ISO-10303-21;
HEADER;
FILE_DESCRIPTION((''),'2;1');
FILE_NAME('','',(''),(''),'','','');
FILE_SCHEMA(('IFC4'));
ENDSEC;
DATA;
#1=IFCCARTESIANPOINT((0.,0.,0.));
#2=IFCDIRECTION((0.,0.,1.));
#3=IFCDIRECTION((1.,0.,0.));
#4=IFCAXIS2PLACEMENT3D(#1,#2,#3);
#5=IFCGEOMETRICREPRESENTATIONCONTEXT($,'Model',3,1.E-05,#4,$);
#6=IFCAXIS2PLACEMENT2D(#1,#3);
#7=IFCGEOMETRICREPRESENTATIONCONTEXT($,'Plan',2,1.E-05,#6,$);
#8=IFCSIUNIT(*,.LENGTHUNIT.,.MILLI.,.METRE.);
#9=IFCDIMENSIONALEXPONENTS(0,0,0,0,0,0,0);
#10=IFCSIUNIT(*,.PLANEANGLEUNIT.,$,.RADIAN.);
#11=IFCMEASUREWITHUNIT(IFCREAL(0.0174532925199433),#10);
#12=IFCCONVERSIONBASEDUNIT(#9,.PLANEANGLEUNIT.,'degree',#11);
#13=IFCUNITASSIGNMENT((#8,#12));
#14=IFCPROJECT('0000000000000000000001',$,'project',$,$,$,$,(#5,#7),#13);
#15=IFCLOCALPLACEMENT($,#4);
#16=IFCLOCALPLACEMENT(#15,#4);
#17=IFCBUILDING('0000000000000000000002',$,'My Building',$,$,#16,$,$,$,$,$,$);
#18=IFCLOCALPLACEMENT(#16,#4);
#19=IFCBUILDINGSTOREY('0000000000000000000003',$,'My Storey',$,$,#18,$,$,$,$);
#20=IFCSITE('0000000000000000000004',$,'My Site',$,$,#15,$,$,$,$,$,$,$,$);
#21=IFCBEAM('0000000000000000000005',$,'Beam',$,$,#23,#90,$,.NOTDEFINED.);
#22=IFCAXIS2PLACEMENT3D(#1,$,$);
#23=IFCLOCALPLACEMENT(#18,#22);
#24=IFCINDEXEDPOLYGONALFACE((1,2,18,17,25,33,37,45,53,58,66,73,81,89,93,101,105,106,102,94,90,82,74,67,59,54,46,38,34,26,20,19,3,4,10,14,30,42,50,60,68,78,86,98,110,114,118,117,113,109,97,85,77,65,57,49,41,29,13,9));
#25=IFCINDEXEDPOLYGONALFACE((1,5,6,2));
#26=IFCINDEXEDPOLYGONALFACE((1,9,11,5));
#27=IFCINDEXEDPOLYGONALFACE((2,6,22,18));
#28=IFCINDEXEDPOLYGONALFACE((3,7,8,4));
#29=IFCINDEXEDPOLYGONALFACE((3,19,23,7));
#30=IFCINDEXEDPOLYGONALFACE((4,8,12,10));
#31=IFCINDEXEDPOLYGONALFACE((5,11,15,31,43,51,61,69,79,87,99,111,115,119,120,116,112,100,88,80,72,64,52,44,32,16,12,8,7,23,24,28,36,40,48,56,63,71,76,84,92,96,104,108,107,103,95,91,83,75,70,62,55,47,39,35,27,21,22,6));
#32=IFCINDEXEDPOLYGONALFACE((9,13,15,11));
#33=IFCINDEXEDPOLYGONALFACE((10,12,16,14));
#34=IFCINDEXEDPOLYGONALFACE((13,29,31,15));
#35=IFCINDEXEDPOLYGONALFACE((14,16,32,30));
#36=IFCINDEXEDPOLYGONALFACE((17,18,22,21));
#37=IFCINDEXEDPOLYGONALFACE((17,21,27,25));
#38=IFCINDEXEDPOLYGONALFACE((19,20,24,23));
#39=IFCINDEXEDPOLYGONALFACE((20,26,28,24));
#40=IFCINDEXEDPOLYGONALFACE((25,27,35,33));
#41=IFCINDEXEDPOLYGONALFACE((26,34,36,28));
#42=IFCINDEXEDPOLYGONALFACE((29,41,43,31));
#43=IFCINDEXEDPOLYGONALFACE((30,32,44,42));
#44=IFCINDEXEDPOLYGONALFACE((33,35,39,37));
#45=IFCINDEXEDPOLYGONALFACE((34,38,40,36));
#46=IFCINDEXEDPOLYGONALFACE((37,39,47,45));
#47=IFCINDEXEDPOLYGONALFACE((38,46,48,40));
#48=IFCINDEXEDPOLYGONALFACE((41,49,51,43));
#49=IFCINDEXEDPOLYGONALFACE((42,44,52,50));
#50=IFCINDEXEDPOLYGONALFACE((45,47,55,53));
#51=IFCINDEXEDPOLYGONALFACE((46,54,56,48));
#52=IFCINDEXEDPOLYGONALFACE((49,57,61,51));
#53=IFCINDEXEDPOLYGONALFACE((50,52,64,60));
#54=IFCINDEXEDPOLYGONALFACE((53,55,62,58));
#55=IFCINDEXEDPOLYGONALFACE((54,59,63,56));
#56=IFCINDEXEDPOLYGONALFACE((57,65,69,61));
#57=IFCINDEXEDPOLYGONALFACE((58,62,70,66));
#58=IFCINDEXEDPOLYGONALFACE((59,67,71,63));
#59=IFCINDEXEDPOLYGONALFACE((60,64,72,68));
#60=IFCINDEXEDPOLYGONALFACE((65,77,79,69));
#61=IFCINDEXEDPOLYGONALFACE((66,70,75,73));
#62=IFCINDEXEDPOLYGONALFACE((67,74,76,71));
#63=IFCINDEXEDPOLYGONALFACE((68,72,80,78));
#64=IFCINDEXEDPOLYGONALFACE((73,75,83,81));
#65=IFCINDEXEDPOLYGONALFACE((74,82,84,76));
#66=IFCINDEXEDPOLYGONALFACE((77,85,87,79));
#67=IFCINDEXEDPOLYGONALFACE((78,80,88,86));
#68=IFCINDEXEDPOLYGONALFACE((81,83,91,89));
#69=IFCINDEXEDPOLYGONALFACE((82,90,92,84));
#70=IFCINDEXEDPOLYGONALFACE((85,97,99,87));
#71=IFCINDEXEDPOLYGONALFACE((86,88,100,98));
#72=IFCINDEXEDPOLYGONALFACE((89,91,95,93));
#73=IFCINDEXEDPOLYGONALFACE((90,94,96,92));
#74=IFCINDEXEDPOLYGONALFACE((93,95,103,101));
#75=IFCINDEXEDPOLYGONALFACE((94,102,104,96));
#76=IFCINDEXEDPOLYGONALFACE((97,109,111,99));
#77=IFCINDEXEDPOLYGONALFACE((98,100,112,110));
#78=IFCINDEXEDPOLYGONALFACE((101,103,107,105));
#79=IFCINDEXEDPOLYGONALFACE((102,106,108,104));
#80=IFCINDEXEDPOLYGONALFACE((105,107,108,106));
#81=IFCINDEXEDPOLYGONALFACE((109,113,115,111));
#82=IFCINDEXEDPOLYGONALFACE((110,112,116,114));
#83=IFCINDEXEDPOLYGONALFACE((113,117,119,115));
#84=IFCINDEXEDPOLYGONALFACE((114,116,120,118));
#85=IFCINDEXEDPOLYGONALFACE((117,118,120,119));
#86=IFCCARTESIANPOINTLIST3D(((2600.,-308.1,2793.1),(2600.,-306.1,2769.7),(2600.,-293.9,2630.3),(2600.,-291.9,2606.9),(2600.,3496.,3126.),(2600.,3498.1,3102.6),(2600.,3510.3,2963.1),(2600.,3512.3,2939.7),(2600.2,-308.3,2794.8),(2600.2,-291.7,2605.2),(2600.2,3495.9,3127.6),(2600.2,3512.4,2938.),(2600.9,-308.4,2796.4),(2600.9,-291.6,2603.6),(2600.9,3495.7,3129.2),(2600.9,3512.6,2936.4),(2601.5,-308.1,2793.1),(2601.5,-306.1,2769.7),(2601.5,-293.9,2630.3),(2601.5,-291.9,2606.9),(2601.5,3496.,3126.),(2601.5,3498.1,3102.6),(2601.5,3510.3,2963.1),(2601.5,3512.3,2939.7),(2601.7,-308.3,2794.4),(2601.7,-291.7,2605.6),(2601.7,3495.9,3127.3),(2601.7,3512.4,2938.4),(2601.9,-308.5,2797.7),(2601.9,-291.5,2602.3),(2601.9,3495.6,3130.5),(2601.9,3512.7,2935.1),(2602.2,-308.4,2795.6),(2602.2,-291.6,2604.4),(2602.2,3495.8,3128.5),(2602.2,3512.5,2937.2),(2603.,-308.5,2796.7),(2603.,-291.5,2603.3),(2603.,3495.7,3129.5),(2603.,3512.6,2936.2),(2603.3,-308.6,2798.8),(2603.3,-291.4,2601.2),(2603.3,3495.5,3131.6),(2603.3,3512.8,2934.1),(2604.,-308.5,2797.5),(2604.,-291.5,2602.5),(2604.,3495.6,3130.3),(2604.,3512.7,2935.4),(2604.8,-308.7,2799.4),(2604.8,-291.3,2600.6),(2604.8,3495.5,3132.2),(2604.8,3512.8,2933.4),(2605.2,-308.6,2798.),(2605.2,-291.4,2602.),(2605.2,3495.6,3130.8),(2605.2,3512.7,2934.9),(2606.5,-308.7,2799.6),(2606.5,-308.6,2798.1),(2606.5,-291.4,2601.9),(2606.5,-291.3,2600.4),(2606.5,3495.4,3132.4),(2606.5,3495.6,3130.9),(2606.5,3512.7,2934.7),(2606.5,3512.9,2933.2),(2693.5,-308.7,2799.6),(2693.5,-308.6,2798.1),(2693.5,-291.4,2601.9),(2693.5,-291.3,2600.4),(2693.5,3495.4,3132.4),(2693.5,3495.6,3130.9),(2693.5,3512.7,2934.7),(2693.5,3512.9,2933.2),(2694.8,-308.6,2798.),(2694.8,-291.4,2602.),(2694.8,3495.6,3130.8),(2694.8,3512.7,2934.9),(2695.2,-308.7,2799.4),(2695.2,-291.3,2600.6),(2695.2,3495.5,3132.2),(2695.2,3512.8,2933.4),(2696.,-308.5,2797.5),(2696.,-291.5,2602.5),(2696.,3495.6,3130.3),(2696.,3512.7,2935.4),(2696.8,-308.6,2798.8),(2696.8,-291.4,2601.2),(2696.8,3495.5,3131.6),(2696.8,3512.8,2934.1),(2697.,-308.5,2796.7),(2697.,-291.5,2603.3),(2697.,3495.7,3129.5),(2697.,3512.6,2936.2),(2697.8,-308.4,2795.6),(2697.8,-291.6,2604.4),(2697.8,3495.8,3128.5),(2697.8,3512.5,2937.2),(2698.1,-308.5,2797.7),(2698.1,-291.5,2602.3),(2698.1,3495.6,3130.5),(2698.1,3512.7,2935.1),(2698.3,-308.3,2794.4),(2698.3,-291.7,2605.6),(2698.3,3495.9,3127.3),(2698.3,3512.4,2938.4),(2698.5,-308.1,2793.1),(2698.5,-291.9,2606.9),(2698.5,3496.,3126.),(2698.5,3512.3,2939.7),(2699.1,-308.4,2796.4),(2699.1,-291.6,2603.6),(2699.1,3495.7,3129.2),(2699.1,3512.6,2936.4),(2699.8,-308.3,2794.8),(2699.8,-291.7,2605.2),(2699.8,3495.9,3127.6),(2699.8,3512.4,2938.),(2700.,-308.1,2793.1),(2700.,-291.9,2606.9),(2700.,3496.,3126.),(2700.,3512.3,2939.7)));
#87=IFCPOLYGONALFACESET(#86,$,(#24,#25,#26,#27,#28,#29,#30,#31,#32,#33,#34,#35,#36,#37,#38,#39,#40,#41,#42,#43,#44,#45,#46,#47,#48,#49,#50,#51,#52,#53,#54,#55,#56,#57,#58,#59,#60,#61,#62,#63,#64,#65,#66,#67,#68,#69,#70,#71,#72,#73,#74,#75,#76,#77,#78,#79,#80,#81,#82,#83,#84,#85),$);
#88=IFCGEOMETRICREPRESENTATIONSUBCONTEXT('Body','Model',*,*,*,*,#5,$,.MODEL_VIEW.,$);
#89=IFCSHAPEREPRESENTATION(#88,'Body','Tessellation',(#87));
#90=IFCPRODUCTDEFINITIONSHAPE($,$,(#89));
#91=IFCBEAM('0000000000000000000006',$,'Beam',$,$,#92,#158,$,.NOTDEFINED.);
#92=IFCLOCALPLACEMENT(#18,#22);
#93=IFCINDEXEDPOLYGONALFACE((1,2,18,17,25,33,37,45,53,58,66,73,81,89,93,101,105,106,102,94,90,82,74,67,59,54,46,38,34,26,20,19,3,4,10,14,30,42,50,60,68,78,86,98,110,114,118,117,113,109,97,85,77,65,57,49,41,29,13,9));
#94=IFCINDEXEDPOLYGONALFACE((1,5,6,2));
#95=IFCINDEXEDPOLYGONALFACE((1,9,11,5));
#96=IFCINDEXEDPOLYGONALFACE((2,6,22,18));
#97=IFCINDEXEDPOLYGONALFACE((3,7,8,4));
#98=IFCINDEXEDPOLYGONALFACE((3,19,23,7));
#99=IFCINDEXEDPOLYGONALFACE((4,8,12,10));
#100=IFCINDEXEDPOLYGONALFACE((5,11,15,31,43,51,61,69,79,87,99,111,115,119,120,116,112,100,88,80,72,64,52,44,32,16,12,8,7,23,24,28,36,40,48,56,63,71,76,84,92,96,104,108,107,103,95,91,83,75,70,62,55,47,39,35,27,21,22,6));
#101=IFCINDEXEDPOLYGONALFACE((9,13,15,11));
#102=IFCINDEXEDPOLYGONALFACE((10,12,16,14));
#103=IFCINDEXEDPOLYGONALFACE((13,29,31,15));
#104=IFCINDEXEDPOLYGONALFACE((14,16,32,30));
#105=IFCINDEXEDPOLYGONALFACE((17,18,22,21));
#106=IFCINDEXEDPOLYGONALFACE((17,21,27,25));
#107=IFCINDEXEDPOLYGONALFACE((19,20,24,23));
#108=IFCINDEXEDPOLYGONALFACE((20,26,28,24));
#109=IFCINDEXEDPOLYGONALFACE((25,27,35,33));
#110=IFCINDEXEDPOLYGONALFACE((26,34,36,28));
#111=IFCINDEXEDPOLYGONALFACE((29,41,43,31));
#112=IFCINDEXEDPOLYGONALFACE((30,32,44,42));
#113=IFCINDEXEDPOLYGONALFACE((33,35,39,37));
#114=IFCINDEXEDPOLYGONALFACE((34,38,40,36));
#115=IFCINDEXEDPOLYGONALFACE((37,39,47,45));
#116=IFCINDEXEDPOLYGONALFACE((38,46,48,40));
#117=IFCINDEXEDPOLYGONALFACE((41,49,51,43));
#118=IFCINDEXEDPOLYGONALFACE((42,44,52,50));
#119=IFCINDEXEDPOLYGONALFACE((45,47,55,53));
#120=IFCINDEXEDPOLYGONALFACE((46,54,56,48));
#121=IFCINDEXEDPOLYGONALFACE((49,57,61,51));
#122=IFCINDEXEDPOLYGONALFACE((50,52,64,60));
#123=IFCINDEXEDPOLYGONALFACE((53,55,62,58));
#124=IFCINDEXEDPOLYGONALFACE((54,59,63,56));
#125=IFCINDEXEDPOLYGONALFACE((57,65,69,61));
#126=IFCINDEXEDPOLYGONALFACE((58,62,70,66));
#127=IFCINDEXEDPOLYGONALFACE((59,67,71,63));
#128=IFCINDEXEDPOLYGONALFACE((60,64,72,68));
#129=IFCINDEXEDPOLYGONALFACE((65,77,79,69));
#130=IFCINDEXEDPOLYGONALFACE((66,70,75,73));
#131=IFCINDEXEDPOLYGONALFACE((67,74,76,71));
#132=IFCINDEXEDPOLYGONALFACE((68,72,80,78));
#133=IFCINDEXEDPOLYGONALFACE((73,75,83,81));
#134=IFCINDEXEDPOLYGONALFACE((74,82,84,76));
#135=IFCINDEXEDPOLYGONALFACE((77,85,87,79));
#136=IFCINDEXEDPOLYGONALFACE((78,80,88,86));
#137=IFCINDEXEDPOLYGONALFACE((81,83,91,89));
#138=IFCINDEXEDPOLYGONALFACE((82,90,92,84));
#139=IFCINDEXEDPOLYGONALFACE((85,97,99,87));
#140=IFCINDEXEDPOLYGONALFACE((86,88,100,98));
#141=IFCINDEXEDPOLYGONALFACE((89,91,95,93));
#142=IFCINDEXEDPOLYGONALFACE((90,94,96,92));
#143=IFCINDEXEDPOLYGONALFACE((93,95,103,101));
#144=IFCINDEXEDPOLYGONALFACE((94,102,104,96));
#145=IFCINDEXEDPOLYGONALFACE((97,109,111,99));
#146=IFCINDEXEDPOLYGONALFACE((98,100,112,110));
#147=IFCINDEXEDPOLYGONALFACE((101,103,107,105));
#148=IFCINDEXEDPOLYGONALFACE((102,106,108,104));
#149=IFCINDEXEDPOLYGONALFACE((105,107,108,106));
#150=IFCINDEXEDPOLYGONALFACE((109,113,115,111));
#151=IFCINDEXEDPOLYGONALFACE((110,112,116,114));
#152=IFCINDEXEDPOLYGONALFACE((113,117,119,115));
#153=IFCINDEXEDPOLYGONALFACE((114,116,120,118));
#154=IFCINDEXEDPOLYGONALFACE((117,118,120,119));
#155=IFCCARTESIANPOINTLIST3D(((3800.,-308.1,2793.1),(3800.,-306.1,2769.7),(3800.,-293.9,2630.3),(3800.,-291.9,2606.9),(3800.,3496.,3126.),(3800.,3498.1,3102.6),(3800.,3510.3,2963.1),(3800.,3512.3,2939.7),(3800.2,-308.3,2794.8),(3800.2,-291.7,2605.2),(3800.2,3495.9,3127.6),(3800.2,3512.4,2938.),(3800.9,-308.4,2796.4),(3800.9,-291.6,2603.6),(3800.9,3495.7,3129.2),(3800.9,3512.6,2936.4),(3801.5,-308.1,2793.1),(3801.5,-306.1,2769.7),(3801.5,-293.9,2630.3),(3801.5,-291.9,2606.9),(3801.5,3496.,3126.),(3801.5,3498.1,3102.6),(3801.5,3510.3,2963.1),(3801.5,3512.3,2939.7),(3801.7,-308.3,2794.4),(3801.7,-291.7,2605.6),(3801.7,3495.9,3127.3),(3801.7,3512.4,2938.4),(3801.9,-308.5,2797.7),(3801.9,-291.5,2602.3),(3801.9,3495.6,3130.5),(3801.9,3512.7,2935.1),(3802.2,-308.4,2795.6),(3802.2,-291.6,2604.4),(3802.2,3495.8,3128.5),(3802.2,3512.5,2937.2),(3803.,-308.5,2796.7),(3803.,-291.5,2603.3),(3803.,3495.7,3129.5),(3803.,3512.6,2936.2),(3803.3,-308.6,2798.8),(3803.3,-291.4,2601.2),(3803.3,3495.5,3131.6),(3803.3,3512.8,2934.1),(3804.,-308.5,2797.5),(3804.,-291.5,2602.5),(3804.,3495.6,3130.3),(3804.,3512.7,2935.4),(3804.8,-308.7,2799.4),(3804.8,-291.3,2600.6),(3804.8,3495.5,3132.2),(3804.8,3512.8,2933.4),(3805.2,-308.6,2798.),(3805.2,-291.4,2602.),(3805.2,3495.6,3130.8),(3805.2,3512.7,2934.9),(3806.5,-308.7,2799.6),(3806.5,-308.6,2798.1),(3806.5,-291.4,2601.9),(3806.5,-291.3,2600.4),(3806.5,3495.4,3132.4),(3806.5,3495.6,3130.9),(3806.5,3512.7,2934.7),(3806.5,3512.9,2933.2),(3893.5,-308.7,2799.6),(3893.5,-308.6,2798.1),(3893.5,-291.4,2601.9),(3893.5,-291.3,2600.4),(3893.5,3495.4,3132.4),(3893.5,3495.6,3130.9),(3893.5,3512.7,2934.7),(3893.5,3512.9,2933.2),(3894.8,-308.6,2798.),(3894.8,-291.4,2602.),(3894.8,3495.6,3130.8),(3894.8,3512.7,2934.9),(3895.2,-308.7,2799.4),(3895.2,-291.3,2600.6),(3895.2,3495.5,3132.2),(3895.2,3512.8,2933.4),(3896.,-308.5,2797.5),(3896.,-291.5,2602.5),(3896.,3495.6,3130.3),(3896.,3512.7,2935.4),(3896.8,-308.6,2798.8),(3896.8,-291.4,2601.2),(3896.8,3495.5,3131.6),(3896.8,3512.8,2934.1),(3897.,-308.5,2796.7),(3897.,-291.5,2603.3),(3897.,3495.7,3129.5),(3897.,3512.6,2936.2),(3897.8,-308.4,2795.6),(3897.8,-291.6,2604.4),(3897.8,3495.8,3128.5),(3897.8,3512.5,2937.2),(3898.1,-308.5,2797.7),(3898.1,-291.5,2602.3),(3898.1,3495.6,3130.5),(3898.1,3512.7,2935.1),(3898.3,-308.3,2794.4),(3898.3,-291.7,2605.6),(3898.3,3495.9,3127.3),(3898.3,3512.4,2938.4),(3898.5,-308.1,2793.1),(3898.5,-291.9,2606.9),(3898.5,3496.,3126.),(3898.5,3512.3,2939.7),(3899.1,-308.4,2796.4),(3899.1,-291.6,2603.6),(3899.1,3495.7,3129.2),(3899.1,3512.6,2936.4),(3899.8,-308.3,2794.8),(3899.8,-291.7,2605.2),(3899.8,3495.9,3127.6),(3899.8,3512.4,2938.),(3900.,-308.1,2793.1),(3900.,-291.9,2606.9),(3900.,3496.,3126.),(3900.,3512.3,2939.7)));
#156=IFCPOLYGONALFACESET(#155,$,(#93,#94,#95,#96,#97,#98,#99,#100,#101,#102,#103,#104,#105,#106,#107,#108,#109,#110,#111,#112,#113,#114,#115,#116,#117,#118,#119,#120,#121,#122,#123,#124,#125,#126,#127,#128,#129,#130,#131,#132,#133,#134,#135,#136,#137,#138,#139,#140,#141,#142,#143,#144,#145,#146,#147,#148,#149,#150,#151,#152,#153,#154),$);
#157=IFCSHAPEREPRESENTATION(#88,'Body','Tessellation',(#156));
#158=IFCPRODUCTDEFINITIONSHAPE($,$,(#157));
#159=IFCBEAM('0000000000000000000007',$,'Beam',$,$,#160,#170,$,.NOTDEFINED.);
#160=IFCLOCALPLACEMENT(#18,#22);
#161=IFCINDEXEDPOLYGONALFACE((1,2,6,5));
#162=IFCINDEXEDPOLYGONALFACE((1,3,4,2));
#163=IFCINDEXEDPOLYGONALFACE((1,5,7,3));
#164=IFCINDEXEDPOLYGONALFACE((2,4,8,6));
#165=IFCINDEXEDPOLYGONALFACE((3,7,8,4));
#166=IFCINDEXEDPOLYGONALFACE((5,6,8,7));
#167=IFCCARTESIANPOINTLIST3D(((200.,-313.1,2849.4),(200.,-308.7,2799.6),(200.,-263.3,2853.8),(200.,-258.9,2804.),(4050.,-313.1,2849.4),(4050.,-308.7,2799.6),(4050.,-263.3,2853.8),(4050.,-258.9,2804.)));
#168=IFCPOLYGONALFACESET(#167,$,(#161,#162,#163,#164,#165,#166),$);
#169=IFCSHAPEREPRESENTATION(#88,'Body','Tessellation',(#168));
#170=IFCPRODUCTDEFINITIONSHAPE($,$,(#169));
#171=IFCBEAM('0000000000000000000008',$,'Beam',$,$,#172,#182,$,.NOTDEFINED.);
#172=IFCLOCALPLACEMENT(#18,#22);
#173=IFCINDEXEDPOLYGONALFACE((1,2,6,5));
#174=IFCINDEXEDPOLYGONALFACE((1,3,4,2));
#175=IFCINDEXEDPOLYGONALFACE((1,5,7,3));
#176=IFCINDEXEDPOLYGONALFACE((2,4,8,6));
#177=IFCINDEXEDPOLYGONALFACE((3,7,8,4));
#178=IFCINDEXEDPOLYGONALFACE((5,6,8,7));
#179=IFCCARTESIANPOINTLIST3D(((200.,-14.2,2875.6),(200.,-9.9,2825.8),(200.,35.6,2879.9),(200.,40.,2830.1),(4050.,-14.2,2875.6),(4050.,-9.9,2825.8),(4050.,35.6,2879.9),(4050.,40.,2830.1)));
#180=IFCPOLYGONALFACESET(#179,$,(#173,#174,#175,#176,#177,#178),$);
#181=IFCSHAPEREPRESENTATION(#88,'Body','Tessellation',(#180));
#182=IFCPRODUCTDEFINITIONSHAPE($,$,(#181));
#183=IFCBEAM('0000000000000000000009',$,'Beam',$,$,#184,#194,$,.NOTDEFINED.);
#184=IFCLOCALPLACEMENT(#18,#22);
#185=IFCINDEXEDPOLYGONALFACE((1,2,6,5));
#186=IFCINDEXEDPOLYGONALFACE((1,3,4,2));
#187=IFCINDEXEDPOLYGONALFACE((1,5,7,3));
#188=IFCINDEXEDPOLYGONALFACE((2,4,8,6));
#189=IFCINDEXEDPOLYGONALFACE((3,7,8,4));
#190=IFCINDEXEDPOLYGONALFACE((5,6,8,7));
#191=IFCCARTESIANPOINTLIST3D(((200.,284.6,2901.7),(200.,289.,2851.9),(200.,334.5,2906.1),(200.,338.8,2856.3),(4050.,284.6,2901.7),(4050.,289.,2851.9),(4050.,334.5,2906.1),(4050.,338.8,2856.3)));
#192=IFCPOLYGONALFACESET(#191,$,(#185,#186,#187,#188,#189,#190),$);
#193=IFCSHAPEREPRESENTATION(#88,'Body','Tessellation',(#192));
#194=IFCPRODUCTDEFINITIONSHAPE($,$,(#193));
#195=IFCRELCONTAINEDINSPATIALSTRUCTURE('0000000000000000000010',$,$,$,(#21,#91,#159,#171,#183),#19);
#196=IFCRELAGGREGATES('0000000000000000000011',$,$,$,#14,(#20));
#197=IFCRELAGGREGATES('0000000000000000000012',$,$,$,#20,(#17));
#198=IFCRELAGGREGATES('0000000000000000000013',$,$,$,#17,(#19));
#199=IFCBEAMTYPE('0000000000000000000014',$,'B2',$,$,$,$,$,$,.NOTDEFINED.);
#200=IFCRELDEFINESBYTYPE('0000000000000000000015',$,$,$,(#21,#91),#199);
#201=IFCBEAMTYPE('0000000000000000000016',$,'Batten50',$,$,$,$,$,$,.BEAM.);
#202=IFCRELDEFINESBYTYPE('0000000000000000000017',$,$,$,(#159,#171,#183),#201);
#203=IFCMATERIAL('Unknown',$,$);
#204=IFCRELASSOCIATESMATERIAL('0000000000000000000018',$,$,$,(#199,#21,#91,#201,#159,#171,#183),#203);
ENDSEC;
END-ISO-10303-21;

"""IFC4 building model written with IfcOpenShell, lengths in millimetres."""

from ifc_helpers import new_model, entity, si_unit, converted_unit, frame, frame_2d, origin_with_axes, place, context, subcontext, project, spatial, rectangle, c_section, extrude, material, material_profile, profile_set, profile_usage, type_object, element, save


model = new_model("IFC4")

# Units and contexts
model_context = context("Model", 3, precision=1e-05, world=origin_with_axes())
plan_context = context("Plan", 2, precision=1e-05, world=frame_2d((0.0, 0.0, 0.0), x_axis=(1.0, 0.0, 0.0)))
body_context = subcontext(model_context, "Body", "Model", "MODEL_VIEW")
ifc_project = project(units=[si_unit("LENGTHUNIT", "METRE", prefix="MILLI"), converted_unit("PLANEANGLEUNIT", "degree", entity("IfcReal", 0.0174532925199433), si_unit("PLANEANGLEUNIT", "RADIAN"), dimensions=[0, 0, 0, 0, 0, 0, 0])], contexts=[model_context, plan_context])

# Site, building, storey
site_placement = place(None, origin_with_axes())
site = spatial("IfcSite", under=ifc_project, at=site_placement, Name="My Site")
building_placement = place(site_placement, origin_with_axes())
building = spatial("IfcBuilding", under=site, at=building_placement, Name="My Building")
storey_placement = place(building_placement, origin_with_axes())
storey = spatial("IfcBuildingStorey", under=building, at=storey_placement, Name="My Storey")

# Shared definitions
ifc_material = material(Name="Unknown")

# Beams
ifc_material_profile_1 = material_profile(ifc_material, c_section(Depth=200.0, Width=100.0, WallThickness=1.5, Girth=30.0, InternalFilletRadius=5.0))
ifc_profile_set_1 = profile_set([ifc_material_profile_1])
beam_type_1 = type_object("IfcBeamType", Name="B2", PredefinedType="NOTDEFINED", material=ifc_profile_set_1)
ifc_profile_usage_1 = profile_usage(ifc_profile_set_1, cardinal=5)
beam_1_placement = place(storey_placement, frame((2650.0, -300.0, 2700.0), z_axis=(0.0, 0.996195, 0.087156), x_axis=(-1.0, 0.0, 0.0)))
element("IfcBeam", 1, at=beam_1_placement, inside=storey, type_object=beam_type_1, material=ifc_profile_usage_1, Name="Beam", PredefinedType="NOTDEFINED", context=body_context, shape_type="SweptSolid", body=[
    extrude(c_section(Depth=200.0, Width=100.0, WallThickness=1.5, Girth=30.0, InternalFilletRadius=5.0), origin_with_axes(), (0.0, 0.0, 1.0), 3818.7),
])
ifc_profile_usage_2 = profile_usage(ifc_profile_set_1, cardinal=5)
beam_2_placement = place(storey_placement, frame((3850.0, -300.0, 2700.0), z_axis=(0.0, 0.996195, 0.087156), x_axis=(-1.0, 0.0, 0.0)))
element("IfcBeam", 2, at=beam_2_placement, inside=storey, type_object=beam_type_1, material=ifc_profile_usage_2, Name="Beam", PredefinedType="NOTDEFINED", context=body_context, shape_type="SweptSolid", body=[
    extrude(c_section(Depth=200.0, Width=100.0, WallThickness=1.5, Girth=30.0, InternalFilletRadius=5.0), origin_with_axes(), (0.0, 0.0, 1.0), 3818.7),
])
ifc_material_profile_2 = material_profile(ifc_material, rectangle(XDim=50.0, YDim=50.0))
ifc_profile_set_2 = profile_set([ifc_material_profile_2], Name="blank")
ifc_profile_usage_3 = profile_usage(ifc_profile_set_2, cardinal=5)
beam_type_2 = type_object("IfcBeamType", Name="Batten50", PredefinedType="BEAM", material=ifc_profile_set_2)
beam_3_placement = place(storey_placement, frame((200.0, -286.0, 2826.7), z_axis=(1.0, 0.0, 0.0), x_axis=(0.0, 0.996195, 0.087156)))
element("IfcBeam", 3, at=beam_3_placement, inside=storey, type_object=beam_type_2, material=ifc_profile_usage_3, Name="Beam", PredefinedType="NOTDEFINED", context=body_context, shape_type="SweptSolid", body=[
    extrude(rectangle(XDim=50.0, YDim=50.0), origin_with_axes(), (0.0, 0.0, 1.0), 3850.0),
])
ifc_profile_usage_4 = profile_usage(ifc_profile_set_2, cardinal=5)
beam_4_placement = place(storey_placement, frame((200.0, 12.9, 2852.9), z_axis=(1.0, 0.0, 0.0), x_axis=(0.0, 0.996195, 0.087156)))
element("IfcBeam", 4, at=beam_4_placement, inside=storey, type_object=beam_type_2, material=ifc_profile_usage_4, Name="Beam", PredefinedType="NOTDEFINED", context=body_context, shape_type="SweptSolid", body=[
    extrude(rectangle(XDim=50.0, YDim=50.0), origin_with_axes(), (0.0, 0.0, 1.0), 3850.0),
])
ifc_profile_usage_5 = profile_usage(ifc_profile_set_2, cardinal=5)
beam_5_placement = place(storey_placement, frame((200.0, 311.7, 2879.0), z_axis=(1.0, 0.0, 0.0), x_axis=(0.0, 0.996195, 0.087156)))
element("IfcBeam", 5, at=beam_5_placement, inside=storey, type_object=beam_type_2, material=ifc_profile_usage_5, Name="Beam", PredefinedType="NOTDEFINED", context=body_context, shape_type="SweptSolid", body=[
    extrude(rectangle(XDim=50.0, YDim=50.0), origin_with_axes(), (0.0, 0.0, 1.0), 3850.0),
])

save(model, "model.ifc")
